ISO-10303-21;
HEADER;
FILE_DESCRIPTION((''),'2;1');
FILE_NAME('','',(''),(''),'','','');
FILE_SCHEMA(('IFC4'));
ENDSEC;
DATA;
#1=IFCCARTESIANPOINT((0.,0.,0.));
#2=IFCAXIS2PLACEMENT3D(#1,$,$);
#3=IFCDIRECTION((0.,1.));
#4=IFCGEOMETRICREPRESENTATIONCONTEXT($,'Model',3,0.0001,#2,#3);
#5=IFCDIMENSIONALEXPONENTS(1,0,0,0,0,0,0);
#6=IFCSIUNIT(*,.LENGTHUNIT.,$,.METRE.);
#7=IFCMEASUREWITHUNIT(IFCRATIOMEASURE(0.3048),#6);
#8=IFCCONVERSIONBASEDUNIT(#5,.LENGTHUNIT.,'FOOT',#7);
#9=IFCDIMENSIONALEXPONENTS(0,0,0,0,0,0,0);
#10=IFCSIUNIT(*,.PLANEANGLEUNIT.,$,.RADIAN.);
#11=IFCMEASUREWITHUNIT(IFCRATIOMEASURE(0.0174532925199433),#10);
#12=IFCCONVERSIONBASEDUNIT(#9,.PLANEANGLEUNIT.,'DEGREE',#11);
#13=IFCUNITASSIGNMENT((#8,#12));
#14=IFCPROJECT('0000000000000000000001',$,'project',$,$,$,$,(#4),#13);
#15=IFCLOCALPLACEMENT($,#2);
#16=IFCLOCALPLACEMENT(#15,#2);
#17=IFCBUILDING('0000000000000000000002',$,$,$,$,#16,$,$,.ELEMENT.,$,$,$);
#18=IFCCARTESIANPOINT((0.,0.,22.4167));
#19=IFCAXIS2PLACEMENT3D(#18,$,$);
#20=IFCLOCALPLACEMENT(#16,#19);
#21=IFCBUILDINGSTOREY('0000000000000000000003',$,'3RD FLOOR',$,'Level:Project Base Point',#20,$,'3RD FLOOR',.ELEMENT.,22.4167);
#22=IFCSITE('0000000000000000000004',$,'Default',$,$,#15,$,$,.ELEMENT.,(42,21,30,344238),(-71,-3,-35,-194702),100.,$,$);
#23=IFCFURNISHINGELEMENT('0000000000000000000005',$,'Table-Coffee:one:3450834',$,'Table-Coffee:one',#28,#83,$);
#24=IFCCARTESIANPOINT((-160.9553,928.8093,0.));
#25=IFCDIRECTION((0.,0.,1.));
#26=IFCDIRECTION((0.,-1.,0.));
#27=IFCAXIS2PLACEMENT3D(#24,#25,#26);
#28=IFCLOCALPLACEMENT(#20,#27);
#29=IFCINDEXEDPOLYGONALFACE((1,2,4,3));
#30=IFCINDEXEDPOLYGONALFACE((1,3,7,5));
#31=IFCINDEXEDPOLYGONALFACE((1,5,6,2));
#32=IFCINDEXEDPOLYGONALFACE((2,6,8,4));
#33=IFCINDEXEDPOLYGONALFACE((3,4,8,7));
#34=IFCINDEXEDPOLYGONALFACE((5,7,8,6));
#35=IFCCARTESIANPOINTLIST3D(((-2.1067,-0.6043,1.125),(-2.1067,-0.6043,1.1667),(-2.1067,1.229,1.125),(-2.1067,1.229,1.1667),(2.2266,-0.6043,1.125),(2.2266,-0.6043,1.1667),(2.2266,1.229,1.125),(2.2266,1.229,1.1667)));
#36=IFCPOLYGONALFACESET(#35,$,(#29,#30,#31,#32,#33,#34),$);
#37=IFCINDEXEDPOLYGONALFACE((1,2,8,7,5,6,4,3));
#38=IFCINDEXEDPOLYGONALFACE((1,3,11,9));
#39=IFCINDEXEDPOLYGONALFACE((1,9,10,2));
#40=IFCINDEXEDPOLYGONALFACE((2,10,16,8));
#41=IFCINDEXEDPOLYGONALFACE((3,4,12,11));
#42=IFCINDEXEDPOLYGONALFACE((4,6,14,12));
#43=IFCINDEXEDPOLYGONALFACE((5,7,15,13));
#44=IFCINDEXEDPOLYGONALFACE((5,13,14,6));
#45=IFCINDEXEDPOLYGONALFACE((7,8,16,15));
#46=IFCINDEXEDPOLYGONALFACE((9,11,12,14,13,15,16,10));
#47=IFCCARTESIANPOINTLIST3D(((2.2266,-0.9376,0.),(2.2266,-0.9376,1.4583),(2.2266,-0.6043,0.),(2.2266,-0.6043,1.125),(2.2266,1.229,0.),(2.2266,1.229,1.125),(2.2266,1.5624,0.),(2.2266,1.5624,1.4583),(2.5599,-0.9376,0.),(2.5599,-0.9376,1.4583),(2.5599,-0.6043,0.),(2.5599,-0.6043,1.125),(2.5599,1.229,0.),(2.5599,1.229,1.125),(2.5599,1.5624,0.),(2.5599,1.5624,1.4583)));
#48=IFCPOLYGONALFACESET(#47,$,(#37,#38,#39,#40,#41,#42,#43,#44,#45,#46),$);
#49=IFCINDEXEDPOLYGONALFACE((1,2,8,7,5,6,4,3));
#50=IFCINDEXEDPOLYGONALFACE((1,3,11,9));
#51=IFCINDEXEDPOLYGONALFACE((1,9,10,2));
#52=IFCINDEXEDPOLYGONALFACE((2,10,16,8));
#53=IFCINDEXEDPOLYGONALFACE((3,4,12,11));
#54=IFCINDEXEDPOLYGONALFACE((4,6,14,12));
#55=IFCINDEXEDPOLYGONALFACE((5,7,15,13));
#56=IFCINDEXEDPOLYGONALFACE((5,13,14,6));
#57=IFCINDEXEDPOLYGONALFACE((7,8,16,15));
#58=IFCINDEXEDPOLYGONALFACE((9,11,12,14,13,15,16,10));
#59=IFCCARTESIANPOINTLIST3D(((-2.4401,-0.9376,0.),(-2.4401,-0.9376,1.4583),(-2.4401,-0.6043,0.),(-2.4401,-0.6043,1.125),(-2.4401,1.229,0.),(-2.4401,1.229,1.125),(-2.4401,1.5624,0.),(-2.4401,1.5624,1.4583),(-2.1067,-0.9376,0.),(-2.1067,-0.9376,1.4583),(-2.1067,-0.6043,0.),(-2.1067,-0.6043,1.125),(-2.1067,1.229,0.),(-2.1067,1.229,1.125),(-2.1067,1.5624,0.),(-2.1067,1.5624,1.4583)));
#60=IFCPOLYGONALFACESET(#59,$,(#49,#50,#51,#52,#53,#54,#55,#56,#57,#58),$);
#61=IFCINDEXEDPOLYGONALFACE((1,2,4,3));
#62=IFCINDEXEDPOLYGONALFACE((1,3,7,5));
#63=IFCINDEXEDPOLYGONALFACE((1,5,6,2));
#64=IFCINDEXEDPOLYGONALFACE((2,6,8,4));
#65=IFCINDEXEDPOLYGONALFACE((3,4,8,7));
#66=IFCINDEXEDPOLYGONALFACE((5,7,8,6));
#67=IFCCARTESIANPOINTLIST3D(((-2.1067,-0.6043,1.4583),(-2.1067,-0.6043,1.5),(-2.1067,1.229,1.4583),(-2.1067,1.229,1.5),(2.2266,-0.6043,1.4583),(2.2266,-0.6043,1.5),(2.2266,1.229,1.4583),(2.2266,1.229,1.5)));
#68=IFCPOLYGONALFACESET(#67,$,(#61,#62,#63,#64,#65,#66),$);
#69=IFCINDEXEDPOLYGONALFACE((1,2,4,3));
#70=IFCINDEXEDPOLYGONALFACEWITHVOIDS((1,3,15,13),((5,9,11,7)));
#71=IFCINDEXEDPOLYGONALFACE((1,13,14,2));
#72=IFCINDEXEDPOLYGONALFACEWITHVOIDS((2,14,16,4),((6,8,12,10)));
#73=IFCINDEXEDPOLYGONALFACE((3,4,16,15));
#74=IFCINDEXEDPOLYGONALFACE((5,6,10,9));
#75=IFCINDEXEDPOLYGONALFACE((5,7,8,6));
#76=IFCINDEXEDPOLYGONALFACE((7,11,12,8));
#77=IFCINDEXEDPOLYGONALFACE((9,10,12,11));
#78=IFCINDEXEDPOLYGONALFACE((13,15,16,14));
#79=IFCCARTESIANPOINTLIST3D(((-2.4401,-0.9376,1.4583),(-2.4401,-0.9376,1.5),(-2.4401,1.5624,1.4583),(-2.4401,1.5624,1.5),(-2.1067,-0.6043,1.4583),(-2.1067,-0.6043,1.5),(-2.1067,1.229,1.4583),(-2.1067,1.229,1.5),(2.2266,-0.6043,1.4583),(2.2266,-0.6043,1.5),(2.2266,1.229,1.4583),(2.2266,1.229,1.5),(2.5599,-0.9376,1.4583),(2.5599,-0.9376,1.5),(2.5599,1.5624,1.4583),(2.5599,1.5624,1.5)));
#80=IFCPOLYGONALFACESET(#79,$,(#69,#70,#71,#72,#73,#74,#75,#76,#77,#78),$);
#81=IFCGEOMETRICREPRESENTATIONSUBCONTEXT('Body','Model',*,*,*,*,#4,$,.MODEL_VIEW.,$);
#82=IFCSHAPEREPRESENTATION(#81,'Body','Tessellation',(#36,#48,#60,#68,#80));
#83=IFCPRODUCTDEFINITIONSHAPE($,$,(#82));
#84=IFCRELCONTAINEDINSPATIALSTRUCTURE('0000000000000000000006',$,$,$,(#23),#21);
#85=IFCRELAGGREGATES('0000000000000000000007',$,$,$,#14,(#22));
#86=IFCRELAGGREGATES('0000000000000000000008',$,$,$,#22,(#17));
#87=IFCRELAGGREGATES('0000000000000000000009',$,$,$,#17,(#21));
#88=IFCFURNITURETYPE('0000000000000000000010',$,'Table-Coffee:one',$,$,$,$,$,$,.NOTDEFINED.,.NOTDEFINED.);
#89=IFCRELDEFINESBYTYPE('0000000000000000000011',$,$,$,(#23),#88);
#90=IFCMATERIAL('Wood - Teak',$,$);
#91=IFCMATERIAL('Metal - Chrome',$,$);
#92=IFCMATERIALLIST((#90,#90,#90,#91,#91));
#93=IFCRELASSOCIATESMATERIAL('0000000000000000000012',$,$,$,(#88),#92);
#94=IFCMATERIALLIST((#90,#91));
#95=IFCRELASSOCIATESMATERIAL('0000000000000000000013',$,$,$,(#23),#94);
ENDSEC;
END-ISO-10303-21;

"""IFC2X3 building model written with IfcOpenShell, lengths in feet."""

from ifc_helpers import new_model, entity, si_unit, converted_unit, direction, frame, origin, origin_2d_with_axis, place, context, subcontext, project, spatial, polyline, rectangle, outline, extrude, source, transform, mapped, material, material_list, type_object, type_shapes, element, save


model = new_model("IFC2X3")

# Units and contexts
model_context = context("Model", 3, precision=0.0001, world=origin(), true_north=direction((0.0, 1.0)))
body_context = subcontext(model_context, "Body", "Model", "MODEL_VIEW")
ifc_project = project(units=[converted_unit("LENGTHUNIT", "FOOT", entity("IfcRatioMeasure", 0.3048), si_unit("LENGTHUNIT", "METRE"), dimensions=[1, 0, 0, 0, 0, 0, 0]), converted_unit("PLANEANGLEUNIT", "DEGREE", entity("IfcRatioMeasure", 0.0174532925199433), si_unit("PLANEANGLEUNIT", "RADIAN"), dimensions=[0, 0, 0, 0, 0, 0, 0])], contexts=[model_context])

# Site, building, storey
site_placement = place(None, origin())
site = spatial("IfcSite", under=ifc_project, at=site_placement, Name="Default", CompositionType="ELEMENT", RefLatitude=(42, 21, 30, 344238), RefLongitude=(-71, -3, -35, -194702), RefElevation=100.0)
building_placement = place(site_placement, origin())
building = spatial("IfcBuilding", under=site, at=building_placement, CompositionType="ELEMENT")
storey_placement = place(building_placement, frame((0.0, 0.0, 22.4167)))
storey = spatial("IfcBuildingStorey", under=building, at=storey_placement, Name="3RD FLOOR", ObjectType="Level:Project Base Point", LongName="3RD FLOOR", CompositionType="ELEMENT", Elevation=22.4167)

# Furnishing element
ifc_material_1 = material(Name="Wood - Teak")
ifc_material_2 = material(Name="Metal - Chrome")
ifc_material_list_1 = material_list([ifc_material_1, ifc_material_2])
ifc_material_list_2 = material_list([ifc_material_1, ifc_material_1, ifc_material_1, ifc_material_2, ifc_material_2])
furniture_type_1 = type_object("IfcFurnitureType", Name="Table-Coffee:one", material=ifc_material_list_2)
shared_shape_1 = source(origin(), body_context, "Body", "SweptSolid", [
    extrude(rectangle(XDim=4.3333, YDim=1.8333, at=origin_2d_with_axis()), frame((0.0599, 0.3124, 1.125), z_axis=(0.0, 0.0, 1.0), x_axis=(-1.0, 0.0, 0.0)), (0.0, 0.0, 1.0), 0.0417),
    extrude(outline(polyline([(-0.6458, -1.25), (0.8125, -1.25), (0.8125, 1.25), (-0.6458, 1.25), (-0.6458, 0.9167), (0.4792, 0.9167), (0.4792, -0.9167), (-0.6458, -0.9167), (-0.6458, -1.25)])), frame((2.2266, 0.3124, 0.6458), z_axis=(1.0, 0.0, 0.0), x_axis=(0.0, 0.0, 1.0)), (0.0, 0.0, 1.0), 0.3333),
    extrude(outline(polyline([(-1.25, -0.8125), (1.25, -0.8125), (1.25, 0.6458), (0.9167, 0.6458), (0.9167, -0.4792), (-0.9167, -0.4792), (-0.9167, 0.6458), (-1.25, 0.6458), (-1.25, -0.8125)])), frame((-2.4401, 0.3124, 0.6458), z_axis=(1.0, 0.0, 0.0), x_axis=(0.0, -1.0, 0.0)), (0.0, 0.0, 1.0), 0.3333),
    extrude(rectangle(XDim=4.3333, YDim=1.8333, at=origin_2d_with_axis()), frame((0.0599, 0.3124, 1.4583), z_axis=(0.0, 0.0, 1.0), x_axis=(-1.0, 0.0, 0.0)), (0.0, 0.0, 1.0), 0.0417),
    extrude(outline(polyline([(-2.5, -1.25), (2.5, -1.25), (2.5, 1.25), (-2.5, 1.25), (-2.5, -1.25)]), holes=[polyline([(-2.1667, -0.9167), (-2.1667, 0.9167), (2.1667, 0.9167), (2.1667, -0.9167), (-2.1667, -0.9167)])]), frame((0.0599, 0.3124, 1.4583), z_axis=(0.0, 0.0, 1.0), x_axis=(-1.0, 0.0, 0.0)), (0.0, 0.0, 1.0), 0.0417),
])
type_shapes(furniture_type_1, [shared_shape_1])
furnishing_1_placement = place(storey_placement, frame((-160.9553, 928.8093, 0.0), z_axis=(0.0, 0.0, 1.0), x_axis=(0.0, -1.0, 0.0)))
element("IfcFurnishingElement", 1, at=furnishing_1_placement, inside=storey, type_object=furniture_type_1, material=ifc_material_list_1, Name="Table-Coffee:one:3450834", ObjectType="Table-Coffee:one", context=body_context, shape_type="MappedRepresentation", body=[
    mapped(shared_shape_1, transform((0.0, 0.0, 0.0), scale=1.0)),
])

save(model, "model.ifc")
